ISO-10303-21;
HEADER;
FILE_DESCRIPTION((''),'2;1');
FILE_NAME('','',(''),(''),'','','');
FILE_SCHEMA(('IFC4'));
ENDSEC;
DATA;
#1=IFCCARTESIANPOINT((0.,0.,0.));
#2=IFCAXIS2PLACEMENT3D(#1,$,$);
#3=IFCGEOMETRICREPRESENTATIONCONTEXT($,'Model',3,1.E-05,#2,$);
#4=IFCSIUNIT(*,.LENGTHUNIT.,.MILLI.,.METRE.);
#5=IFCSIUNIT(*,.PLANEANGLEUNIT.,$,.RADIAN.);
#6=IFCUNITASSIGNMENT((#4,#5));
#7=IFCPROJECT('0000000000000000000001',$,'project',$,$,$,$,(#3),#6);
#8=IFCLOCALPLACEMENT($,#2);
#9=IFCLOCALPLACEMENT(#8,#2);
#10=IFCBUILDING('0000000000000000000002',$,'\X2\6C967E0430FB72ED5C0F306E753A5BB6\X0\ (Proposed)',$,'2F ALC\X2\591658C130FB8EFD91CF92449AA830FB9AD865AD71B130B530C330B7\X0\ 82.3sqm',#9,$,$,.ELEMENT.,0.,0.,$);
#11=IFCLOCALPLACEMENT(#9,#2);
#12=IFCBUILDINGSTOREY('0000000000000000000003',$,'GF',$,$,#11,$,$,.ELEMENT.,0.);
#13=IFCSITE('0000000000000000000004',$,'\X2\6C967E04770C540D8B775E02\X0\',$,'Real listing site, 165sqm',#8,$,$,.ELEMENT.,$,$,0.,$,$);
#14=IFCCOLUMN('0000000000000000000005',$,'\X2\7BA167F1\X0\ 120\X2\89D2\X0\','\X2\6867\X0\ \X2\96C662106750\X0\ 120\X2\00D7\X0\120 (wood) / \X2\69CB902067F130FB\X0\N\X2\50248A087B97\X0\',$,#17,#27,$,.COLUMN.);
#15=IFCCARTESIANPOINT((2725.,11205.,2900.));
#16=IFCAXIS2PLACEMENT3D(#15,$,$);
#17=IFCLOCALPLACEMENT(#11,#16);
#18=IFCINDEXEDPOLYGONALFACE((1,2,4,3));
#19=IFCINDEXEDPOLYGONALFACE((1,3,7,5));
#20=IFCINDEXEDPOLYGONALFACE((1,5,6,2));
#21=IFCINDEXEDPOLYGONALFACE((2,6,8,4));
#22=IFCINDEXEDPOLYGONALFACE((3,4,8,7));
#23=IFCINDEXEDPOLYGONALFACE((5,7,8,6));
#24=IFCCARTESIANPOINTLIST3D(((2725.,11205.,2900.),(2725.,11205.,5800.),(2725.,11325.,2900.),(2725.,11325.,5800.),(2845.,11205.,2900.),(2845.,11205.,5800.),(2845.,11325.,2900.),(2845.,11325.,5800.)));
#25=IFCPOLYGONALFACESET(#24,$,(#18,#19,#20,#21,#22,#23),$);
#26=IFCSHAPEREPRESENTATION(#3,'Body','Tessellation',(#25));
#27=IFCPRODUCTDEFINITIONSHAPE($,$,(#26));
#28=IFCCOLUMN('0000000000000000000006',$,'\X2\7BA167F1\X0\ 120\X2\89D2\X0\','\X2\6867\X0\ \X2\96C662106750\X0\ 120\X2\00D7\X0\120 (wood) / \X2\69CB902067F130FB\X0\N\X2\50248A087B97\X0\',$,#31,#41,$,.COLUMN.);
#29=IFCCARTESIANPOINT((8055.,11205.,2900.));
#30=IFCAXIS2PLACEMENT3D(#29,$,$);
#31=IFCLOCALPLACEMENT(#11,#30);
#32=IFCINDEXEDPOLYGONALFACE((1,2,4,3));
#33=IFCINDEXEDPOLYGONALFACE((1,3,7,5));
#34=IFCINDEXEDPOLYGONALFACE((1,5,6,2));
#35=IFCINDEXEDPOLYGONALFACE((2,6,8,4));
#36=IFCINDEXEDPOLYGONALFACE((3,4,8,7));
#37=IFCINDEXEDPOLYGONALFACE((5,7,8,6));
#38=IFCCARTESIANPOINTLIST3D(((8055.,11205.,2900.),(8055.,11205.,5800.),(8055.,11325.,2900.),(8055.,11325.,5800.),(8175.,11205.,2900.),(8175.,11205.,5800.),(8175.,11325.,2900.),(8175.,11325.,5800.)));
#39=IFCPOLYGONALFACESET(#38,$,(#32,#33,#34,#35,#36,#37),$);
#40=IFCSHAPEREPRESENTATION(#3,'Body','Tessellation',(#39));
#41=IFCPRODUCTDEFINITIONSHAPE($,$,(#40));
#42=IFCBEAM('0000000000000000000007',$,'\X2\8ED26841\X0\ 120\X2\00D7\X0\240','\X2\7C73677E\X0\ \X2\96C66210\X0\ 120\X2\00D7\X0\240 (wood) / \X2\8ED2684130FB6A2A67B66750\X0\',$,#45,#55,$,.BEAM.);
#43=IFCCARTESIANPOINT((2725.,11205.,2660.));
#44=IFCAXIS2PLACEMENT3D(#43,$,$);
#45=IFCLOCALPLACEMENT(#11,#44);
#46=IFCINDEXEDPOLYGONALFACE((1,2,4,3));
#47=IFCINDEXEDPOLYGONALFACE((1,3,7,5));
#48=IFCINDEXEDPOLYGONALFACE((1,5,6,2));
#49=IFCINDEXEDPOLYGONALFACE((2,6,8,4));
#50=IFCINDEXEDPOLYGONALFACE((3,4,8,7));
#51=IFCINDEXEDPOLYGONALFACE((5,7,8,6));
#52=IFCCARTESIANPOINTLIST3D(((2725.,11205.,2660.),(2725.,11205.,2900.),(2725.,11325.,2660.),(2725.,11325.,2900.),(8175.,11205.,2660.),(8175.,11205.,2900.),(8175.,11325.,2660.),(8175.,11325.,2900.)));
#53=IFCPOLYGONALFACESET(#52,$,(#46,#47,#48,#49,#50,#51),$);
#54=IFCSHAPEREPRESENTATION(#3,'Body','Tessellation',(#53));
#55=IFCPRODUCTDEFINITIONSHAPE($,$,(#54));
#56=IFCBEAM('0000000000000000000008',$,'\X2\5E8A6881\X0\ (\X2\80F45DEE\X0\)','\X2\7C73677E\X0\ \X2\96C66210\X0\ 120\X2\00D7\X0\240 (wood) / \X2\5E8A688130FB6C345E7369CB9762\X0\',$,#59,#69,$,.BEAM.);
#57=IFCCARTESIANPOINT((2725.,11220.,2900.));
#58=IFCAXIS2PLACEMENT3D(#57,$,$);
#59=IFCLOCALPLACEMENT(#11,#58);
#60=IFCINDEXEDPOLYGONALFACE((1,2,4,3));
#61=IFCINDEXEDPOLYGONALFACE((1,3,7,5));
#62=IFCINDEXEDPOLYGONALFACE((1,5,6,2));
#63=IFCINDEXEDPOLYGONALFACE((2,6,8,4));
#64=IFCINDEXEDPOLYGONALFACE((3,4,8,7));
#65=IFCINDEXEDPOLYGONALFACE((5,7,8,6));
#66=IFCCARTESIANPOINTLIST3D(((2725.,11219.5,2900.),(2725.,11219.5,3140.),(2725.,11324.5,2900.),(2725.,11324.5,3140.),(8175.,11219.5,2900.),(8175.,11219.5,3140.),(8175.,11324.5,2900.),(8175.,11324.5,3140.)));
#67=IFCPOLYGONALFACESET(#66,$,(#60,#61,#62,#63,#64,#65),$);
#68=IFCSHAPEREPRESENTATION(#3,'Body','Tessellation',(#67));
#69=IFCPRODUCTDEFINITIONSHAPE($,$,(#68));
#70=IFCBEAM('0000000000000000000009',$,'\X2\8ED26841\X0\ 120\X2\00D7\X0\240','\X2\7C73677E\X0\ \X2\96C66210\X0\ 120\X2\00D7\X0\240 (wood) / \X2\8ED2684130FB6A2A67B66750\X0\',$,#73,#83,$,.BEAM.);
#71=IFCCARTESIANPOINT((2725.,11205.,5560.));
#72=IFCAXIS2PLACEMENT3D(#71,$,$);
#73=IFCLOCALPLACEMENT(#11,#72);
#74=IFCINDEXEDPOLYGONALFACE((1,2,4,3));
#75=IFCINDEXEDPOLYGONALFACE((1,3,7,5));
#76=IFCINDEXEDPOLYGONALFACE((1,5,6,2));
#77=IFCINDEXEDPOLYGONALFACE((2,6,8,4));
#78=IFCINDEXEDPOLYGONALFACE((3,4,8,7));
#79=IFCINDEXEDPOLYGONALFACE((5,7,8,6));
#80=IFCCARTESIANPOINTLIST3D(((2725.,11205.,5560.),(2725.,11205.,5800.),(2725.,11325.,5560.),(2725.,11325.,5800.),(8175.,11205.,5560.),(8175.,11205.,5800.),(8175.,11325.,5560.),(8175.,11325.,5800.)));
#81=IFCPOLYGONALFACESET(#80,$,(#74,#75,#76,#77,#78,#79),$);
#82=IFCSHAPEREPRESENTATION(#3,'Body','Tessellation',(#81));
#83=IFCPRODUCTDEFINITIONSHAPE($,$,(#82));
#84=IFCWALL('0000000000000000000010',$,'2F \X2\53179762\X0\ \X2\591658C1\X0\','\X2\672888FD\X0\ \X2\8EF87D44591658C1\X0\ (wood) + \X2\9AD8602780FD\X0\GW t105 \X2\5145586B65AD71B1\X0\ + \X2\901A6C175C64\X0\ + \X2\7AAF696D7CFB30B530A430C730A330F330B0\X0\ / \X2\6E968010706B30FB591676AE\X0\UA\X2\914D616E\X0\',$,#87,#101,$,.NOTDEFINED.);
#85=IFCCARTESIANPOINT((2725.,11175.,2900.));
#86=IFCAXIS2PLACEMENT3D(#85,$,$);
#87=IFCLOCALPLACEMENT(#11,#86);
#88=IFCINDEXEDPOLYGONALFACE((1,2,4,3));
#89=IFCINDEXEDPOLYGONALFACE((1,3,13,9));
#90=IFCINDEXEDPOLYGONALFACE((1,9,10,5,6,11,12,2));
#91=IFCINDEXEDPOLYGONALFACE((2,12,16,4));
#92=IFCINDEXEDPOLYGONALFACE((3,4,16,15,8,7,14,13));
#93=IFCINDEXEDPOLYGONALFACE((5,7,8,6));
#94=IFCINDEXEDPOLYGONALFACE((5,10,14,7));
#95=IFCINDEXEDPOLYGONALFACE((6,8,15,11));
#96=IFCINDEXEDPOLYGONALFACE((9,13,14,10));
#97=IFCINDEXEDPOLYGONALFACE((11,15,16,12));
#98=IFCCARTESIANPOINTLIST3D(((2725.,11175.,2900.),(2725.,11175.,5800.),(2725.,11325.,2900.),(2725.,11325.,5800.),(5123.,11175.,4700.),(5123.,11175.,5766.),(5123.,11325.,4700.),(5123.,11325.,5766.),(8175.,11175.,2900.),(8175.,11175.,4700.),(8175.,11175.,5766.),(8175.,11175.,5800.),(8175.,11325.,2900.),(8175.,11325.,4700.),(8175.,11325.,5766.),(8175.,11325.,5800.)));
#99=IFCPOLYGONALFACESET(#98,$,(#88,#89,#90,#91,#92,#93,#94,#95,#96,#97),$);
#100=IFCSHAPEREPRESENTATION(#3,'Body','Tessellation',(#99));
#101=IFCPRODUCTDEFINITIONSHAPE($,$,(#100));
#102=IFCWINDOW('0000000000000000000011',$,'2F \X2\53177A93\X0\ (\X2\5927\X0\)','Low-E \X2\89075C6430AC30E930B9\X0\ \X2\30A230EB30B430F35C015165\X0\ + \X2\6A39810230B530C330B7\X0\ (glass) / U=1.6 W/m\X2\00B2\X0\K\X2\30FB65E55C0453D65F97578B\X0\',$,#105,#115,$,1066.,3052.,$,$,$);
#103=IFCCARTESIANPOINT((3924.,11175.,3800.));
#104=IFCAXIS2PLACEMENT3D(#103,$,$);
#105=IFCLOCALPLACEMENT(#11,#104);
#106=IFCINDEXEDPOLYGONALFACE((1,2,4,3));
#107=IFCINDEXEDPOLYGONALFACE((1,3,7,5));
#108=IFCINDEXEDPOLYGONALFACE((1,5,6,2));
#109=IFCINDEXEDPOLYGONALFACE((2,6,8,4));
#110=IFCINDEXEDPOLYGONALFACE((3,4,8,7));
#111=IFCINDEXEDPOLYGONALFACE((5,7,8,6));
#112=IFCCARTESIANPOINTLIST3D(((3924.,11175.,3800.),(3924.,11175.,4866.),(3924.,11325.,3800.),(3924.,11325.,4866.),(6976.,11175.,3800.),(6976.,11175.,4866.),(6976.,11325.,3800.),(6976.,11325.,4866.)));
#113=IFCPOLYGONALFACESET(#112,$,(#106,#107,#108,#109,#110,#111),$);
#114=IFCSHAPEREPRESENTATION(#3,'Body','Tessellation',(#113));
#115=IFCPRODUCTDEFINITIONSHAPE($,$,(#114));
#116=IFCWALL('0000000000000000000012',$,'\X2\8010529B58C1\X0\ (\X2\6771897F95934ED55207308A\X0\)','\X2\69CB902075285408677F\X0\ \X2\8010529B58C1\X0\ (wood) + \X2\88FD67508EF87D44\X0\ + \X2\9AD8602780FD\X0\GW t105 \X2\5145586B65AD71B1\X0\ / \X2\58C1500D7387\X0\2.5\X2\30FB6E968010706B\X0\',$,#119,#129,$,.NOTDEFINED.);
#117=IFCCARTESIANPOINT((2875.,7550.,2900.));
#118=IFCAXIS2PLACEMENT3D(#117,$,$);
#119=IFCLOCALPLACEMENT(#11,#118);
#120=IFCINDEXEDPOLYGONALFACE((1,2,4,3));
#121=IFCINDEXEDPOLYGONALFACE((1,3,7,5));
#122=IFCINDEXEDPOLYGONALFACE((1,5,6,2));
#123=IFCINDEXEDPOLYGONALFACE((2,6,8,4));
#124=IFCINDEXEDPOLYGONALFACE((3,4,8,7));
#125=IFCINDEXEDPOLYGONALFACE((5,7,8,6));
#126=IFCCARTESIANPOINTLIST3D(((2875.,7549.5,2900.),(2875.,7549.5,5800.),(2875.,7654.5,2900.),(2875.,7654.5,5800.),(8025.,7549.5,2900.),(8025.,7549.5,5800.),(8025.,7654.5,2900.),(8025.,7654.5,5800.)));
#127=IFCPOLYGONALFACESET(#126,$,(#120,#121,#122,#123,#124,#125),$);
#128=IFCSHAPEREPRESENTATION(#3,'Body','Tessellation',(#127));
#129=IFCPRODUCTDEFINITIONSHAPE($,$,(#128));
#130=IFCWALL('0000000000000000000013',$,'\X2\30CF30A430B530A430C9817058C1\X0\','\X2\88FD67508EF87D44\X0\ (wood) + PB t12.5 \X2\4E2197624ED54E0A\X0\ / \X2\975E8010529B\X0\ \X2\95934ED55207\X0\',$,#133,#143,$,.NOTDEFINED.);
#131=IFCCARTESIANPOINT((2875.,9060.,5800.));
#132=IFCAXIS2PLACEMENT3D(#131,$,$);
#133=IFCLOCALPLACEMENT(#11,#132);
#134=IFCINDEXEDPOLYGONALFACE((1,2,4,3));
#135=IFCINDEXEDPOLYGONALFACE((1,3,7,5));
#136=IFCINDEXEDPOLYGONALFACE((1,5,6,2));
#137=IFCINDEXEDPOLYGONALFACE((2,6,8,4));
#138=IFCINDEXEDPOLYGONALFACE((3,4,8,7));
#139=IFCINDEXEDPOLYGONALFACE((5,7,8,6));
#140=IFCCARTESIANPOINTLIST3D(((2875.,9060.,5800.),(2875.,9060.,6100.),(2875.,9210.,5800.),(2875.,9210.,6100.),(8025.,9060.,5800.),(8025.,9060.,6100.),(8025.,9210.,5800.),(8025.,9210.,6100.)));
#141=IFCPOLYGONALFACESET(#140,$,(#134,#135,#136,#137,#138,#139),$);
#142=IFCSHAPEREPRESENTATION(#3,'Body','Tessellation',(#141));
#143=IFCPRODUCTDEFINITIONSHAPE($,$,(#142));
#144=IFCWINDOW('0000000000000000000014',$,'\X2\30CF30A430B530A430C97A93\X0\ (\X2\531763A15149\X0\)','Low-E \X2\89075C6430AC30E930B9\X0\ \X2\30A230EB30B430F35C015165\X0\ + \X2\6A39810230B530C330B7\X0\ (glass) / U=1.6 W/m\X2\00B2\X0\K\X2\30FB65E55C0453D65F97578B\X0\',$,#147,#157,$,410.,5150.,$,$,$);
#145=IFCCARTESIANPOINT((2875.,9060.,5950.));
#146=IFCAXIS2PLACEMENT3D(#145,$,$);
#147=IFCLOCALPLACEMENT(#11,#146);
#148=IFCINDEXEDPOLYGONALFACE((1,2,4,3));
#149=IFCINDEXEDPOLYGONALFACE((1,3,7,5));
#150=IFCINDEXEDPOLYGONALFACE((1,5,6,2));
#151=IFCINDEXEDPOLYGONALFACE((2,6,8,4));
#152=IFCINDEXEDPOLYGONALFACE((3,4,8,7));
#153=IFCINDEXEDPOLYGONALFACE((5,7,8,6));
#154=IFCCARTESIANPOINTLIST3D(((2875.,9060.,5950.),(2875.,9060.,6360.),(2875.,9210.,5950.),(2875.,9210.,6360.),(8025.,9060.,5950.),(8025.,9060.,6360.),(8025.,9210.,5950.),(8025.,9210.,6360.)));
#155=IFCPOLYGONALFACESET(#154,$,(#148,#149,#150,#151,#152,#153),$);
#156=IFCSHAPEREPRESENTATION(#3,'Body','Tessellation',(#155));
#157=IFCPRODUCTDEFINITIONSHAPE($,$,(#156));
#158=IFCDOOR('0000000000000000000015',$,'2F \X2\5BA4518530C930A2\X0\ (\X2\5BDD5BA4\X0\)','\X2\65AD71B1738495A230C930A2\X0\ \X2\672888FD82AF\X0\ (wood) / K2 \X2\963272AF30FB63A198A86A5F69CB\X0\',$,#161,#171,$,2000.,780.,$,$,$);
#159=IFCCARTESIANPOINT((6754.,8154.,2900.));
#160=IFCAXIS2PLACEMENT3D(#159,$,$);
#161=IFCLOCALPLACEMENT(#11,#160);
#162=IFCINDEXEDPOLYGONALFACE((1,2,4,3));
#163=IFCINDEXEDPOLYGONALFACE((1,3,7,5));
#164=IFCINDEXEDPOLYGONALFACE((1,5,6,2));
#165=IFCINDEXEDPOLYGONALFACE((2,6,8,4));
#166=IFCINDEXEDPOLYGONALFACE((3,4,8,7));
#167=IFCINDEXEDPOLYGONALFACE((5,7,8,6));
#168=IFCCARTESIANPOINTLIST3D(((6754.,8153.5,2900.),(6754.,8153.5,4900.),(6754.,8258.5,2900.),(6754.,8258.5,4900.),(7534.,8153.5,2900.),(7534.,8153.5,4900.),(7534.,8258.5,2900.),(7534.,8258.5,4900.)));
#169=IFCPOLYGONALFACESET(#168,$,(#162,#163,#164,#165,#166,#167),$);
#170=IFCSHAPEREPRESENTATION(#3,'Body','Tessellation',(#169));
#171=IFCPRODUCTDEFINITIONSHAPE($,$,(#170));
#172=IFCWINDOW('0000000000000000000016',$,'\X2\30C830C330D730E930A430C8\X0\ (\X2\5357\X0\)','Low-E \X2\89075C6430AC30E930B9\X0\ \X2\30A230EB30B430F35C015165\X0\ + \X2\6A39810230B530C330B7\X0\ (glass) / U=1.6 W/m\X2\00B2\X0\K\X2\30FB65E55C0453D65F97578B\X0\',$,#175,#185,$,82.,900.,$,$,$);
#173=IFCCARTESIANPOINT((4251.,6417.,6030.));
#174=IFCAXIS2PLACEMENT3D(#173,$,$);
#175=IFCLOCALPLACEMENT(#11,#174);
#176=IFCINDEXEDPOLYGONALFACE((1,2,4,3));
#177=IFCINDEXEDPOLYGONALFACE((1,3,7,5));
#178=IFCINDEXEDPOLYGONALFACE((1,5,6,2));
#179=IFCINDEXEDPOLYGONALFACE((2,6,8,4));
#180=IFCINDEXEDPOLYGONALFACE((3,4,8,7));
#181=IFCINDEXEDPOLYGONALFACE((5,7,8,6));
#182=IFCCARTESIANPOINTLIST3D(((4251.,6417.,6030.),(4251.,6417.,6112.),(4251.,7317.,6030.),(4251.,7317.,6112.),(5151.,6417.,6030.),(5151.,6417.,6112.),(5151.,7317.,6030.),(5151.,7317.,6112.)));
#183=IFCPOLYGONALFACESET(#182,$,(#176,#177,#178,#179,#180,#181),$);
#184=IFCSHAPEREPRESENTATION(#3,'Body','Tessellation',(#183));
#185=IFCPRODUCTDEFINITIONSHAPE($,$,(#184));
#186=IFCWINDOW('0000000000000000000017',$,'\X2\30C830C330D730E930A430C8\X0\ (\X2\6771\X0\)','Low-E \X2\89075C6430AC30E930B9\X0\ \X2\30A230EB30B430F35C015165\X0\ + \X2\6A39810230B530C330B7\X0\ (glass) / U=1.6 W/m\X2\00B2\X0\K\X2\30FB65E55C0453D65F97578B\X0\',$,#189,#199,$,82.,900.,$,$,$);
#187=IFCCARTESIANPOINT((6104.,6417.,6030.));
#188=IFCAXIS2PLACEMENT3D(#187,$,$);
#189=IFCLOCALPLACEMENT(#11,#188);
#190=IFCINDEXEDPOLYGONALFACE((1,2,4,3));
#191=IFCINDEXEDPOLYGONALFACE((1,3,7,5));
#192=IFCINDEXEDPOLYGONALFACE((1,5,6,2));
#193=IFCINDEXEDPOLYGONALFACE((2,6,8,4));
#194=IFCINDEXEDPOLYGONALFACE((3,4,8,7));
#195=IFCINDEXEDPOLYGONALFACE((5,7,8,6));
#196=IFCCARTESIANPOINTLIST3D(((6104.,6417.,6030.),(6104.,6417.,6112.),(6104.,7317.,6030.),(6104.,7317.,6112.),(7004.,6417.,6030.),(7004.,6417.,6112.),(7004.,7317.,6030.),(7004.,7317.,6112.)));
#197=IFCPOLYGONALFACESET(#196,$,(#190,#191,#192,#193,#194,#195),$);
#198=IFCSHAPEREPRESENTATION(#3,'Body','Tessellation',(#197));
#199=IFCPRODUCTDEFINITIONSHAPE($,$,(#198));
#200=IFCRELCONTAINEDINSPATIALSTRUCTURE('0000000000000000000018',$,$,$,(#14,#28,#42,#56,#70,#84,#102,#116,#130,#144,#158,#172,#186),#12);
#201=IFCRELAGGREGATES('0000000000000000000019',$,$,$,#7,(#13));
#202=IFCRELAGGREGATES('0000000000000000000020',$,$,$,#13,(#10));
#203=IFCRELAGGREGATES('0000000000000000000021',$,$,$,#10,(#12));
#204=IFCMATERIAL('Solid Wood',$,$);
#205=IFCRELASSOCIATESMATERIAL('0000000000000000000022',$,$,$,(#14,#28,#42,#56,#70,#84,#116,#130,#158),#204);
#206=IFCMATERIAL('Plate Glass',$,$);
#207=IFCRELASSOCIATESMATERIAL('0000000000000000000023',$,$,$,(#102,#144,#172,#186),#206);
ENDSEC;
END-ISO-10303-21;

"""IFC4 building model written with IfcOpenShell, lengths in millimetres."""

from ifc_helpers import new_model, si_unit, frame, frame_2d, origin, place, context, project, spatial, rectangle, extrude, material, element, fill, save


model = new_model("IFC4")

# Units and contexts
model_context = context("Model", 3, precision=1e-05, world=origin())
ifc_project = project(units=[si_unit("LENGTHUNIT", "METRE", prefix="MILLI"), si_unit("PLANEANGLEUNIT", "RADIAN")], contexts=[model_context])

# Site, building, storey
site_placement = place(None, origin())
site = spatial("IfcSite", under=ifc_project, at=site_placement, Name="沖縄県名護市", ObjectType="Real listing site, 165sqm", CompositionType="ELEMENT", RefElevation=0.0)
building_placement = place(site_placement, origin())
building = spatial("IfcBuilding", under=site, at=building_placement, Name="沖縄・狭小の町家 (Proposed)", ObjectType="2F ALC外壁・軽量鉄骨・高断熱サッシ 82.3sqm", CompositionType="ELEMENT", ElevationOfRefHeight=0.0, ElevationOfTerrain=0.0)
storey_placement = place(building_placement, origin())
storey = spatial("IfcBuildingStorey", under=building, at=storey_placement, Name="GF", CompositionType="ELEMENT", Elevation=0.0)

# Columns
ifc_material_1 = material(Name="Solid Wood")
column_1_placement = place(storey_placement, frame((2725.0, 11205.0, 2900.0)))
element("IfcColumn", 1, at=column_1_placement, inside=storey, material=ifc_material_1, Name="管柱 120角", Description="桧 集成材 120×120 (wood) / 構造柱・N値計算", PredefinedType="COLUMN", context=model_context, shape_type="SweptSolid", body=[
    extrude(rectangle(XDim=120.0, YDim=120.0, at=frame_2d((60.0, 60.0))), frame((2725.0, 11205.0, 2900.0)), (0.0, 0.0, 1.0), 2900.0),
])
column_2_placement = place(storey_placement, frame((8055.0, 11205.0, 2900.0)))
element("IfcColumn", 2, at=column_2_placement, inside=storey, material=ifc_material_1, Name="管柱 120角", Description="桧 集成材 120×120 (wood) / 構造柱・N値計算", PredefinedType="COLUMN", context=model_context, shape_type="SweptSolid", body=[
    extrude(rectangle(XDim=120.0, YDim=120.0, at=frame_2d((60.0, 60.0))), frame((8055.0, 11205.0, 2900.0)), (0.0, 0.0, 1.0), 2900.0),
])

# Beams
beam_1_placement = place(storey_placement, frame((2725.0, 11205.0, 2660.0)))
element("IfcBeam", 3, at=beam_1_placement, inside=storey, material=ifc_material_1, Name="軒桁 120×240", Description="米松 集成 120×240 (wood) / 軒桁・横架材", PredefinedType="BEAM", context=model_context, shape_type="SweptSolid", body=[
    extrude(rectangle(XDim=5450.0, YDim=120.0, at=frame_2d((2725.0, 60.0))), frame((2725.0, 11205.0, 2660.0)), (0.0, 0.0, 1.0), 240.0),
])
beam_2_placement = place(storey_placement, frame((2725.0, 11220.0, 2900.0)))
element("IfcBeam", 4, at=beam_2_placement, inside=storey, material=ifc_material_1, Name="床梁 (胴差)", Description="米松 集成 120×240 (wood) / 床梁・水平構面", PredefinedType="BEAM", context=model_context, shape_type="SweptSolid", body=[
    extrude(rectangle(XDim=5450.0, YDim=105.0, at=frame_2d((2725.0, 52.0))), frame((2725.0, 11220.0, 2900.0)), (0.0, 0.0, 1.0), 240.0),
])
beam_3_placement = place(storey_placement, frame((2725.0, 11205.0, 5560.0)))
element("IfcBeam", 5, at=beam_3_placement, inside=storey, material=ifc_material_1, Name="軒桁 120×240", Description="米松 集成 120×240 (wood) / 軒桁・横架材", PredefinedType="BEAM", context=model_context, shape_type="SweptSolid", body=[
    extrude(rectangle(XDim=5450.0, YDim=120.0, at=frame_2d((2725.0, 60.0))), frame((2725.0, 11205.0, 5560.0)), (0.0, 0.0, 1.0), 240.0),
])

# Wall, opening, window
wall_1_placement = place(storey_placement, frame((2725.0, 11175.0, 2900.0)))
wall_1 = element("IfcWall", 6, at=wall_1_placement, inside=storey, material=ifc_material_1, Name="2F 北面 外壁", Description="木製 軸組外壁 (wood) + 高性能GW t105 充填断熱 + 通気層 + 窯業系サイディング / 準耐火・外皮UA配慮", PredefinedType="NOTDEFINED", context=model_context, shape_type="SweptSolid", body=[
    extrude(rectangle(XDim=5450.0, YDim=150.0, at=frame_2d((2725.0, 75.0))), frame((2725.0, 11175.0, 2900.0)), (0.0, 0.0, 1.0), 2900.0),
])
opening_1_placement = place(storey_placement, frame((3924.0, 11175.0, 3800.0)))
opening_1 = element("IfcOpeningElement", 7, at=opening_1_placement, cuts=wall_1, PredefinedType="NOTDEFINED", context=model_context, shape_type="SweptSolid", body=[
    extrude(rectangle(XDim=3052.0, YDim=150.0, at=frame_2d((1526.0, 75.0))), frame((3924.0, 11175.0, 3800.0)), (0.0, 0.0, 1.0), 1066.0),
])
ifc_material_2 = material(Name="Plate Glass")
window_1_placement = place(storey_placement, frame((3924.0, 11175.0, 3800.0)))
window_1 = element("IfcWindow", 8, at=window_1_placement, inside=storey, material=ifc_material_2, Name="2F 北窓 (大)", Description="Low-E 複層ガラス アルゴン封入 + 樹脂サッシ (glass) / U=1.6 W/m²K・日射取得型", OverallHeight=1066.0, OverallWidth=3052.0, context=model_context, shape_type="SweptSolid", body=[
    extrude(rectangle(XDim=3052.0, YDim=150.0, at=frame_2d((1526.0, 75.0))), frame((3924.0, 11175.0, 3800.0)), (0.0, 0.0, 1.0), 1066.0),
])
fill(opening_1, window_1)

# Wall
wall_2_placement = place(storey_placement, frame((2875.0, 7550.0, 2900.0)))
element("IfcWall", 9, at=wall_2_placement, inside=storey, material=ifc_material_1, Name="耐力壁 (東西間仕切り)", Description="構造用合板 耐力壁 (wood) + 製材軸組 + 高性能GW t105 充填断熱 / 壁倍率2.5・準耐火", PredefinedType="NOTDEFINED", context=model_context, shape_type="SweptSolid", body=[
    extrude(rectangle(XDim=5150.0, YDim=105.0, at=frame_2d((2575.0, 52.0))), frame((2875.0, 7550.0, 2900.0)), (0.0, 0.0, 1.0), 2900.0),
])

# Wall, opening, window
wall_3_placement = place(storey_placement, frame((2875.0, 9060.0, 5800.0)))
wall_3 = element("IfcWall", 10, at=wall_3_placement, inside=storey, material=ifc_material_1, Name="ハイサイド腰壁", Description="製材軸組 (wood) + PB t12.5 両面仕上 / 非耐力 間仕切", PredefinedType="NOTDEFINED", context=model_context, shape_type="SweptSolid", body=[
    extrude(rectangle(XDim=5150.0, YDim=150.0, at=frame_2d((2575.0, 75.0))), frame((2875.0, 9060.0, 5800.0)), (0.0, 0.0, 1.0), 700.0),
])
opening_2_placement = place(storey_placement, frame((2875.0, 9060.0, 5950.0)))
opening_2 = element("IfcOpeningElement", 11, at=opening_2_placement, cuts=wall_3, PredefinedType="NOTDEFINED", context=model_context, shape_type="SweptSolid", body=[
    extrude(rectangle(XDim=5150.0, YDim=150.0, at=frame_2d((2575.0, 75.0))), frame((2875.0, 9060.0, 5950.0)), (0.0, 0.0, 1.0), 410.0),
])
window_2_placement = place(storey_placement, frame((2875.0, 9060.0, 5950.0)))
window_2 = element("IfcWindow", 12, at=window_2_placement, inside=storey, material=ifc_material_2, Name="ハイサイド窓 (北採光)", Description="Low-E 複層ガラス アルゴン封入 + 樹脂サッシ (glass) / U=1.6 W/m²K・日射取得型", OverallHeight=410.0, OverallWidth=5150.0, context=model_context, shape_type="SweptSolid", body=[
    extrude(rectangle(XDim=5150.0, YDim=150.0, at=frame_2d((2575.0, 75.0))), frame((2875.0, 9060.0, 5950.0)), (0.0, 0.0, 1.0), 410.0),
])
fill(opening_2, window_2)

# Door
door_placement = place(storey_placement, frame((6754.0, 8154.0, 2900.0)))
element("IfcDoor", 13, at=door_placement, inside=storey, material=ifc_material_1, Name="2F 室内ドア (寝室)", Description="断熱玄関ドア 木製芯 (wood) / K2 防犯・採風機構", OverallHeight=2000.0, OverallWidth=780.0, context=model_context, shape_type="SweptSolid", body=[
    extrude(rectangle(XDim=780.0, YDim=105.0, at=frame_2d((390.0, 52.0))), frame((6754.0, 8154.0, 2900.0)), (0.0, 0.0, 1.0), 2000.0),
])

# Windows
window_3_placement = place(storey_placement, frame((4251.0, 6417.0, 6030.0)))
element("IfcWindow", 14, at=window_3_placement, inside=storey, material=ifc_material_2, Name="トップライト (南)", Description="Low-E 複層ガラス アルゴン封入 + 樹脂サッシ (glass) / U=1.6 W/m²K・日射取得型", OverallHeight=82.0, OverallWidth=900.0, context=model_context, shape_type="SweptSolid", body=[
    extrude(rectangle(XDim=900.0, YDim=900.0, at=frame_2d((450.0, 450.0))), frame((4251.0, 6417.0, 6030.0)), (0.0, 0.0, 1.0), 82.0),
])
window_4_placement = place(storey_placement, frame((6104.0, 6417.0, 6030.0)))
element("IfcWindow", 15, at=window_4_placement, inside=storey, material=ifc_material_2, Name="トップライト (東)", Description="Low-E 複層ガラス アルゴン封入 + 樹脂サッシ (glass) / U=1.6 W/m²K・日射取得型", OverallHeight=82.0, OverallWidth=900.0, context=model_context, shape_type="SweptSolid", body=[
    extrude(rectangle(XDim=900.0, YDim=900.0, at=frame_2d((450.0, 450.0))), frame((6104.0, 6417.0, 6030.0)), (0.0, 0.0, 1.0), 82.0),
])

save(model, "model.ifc")
